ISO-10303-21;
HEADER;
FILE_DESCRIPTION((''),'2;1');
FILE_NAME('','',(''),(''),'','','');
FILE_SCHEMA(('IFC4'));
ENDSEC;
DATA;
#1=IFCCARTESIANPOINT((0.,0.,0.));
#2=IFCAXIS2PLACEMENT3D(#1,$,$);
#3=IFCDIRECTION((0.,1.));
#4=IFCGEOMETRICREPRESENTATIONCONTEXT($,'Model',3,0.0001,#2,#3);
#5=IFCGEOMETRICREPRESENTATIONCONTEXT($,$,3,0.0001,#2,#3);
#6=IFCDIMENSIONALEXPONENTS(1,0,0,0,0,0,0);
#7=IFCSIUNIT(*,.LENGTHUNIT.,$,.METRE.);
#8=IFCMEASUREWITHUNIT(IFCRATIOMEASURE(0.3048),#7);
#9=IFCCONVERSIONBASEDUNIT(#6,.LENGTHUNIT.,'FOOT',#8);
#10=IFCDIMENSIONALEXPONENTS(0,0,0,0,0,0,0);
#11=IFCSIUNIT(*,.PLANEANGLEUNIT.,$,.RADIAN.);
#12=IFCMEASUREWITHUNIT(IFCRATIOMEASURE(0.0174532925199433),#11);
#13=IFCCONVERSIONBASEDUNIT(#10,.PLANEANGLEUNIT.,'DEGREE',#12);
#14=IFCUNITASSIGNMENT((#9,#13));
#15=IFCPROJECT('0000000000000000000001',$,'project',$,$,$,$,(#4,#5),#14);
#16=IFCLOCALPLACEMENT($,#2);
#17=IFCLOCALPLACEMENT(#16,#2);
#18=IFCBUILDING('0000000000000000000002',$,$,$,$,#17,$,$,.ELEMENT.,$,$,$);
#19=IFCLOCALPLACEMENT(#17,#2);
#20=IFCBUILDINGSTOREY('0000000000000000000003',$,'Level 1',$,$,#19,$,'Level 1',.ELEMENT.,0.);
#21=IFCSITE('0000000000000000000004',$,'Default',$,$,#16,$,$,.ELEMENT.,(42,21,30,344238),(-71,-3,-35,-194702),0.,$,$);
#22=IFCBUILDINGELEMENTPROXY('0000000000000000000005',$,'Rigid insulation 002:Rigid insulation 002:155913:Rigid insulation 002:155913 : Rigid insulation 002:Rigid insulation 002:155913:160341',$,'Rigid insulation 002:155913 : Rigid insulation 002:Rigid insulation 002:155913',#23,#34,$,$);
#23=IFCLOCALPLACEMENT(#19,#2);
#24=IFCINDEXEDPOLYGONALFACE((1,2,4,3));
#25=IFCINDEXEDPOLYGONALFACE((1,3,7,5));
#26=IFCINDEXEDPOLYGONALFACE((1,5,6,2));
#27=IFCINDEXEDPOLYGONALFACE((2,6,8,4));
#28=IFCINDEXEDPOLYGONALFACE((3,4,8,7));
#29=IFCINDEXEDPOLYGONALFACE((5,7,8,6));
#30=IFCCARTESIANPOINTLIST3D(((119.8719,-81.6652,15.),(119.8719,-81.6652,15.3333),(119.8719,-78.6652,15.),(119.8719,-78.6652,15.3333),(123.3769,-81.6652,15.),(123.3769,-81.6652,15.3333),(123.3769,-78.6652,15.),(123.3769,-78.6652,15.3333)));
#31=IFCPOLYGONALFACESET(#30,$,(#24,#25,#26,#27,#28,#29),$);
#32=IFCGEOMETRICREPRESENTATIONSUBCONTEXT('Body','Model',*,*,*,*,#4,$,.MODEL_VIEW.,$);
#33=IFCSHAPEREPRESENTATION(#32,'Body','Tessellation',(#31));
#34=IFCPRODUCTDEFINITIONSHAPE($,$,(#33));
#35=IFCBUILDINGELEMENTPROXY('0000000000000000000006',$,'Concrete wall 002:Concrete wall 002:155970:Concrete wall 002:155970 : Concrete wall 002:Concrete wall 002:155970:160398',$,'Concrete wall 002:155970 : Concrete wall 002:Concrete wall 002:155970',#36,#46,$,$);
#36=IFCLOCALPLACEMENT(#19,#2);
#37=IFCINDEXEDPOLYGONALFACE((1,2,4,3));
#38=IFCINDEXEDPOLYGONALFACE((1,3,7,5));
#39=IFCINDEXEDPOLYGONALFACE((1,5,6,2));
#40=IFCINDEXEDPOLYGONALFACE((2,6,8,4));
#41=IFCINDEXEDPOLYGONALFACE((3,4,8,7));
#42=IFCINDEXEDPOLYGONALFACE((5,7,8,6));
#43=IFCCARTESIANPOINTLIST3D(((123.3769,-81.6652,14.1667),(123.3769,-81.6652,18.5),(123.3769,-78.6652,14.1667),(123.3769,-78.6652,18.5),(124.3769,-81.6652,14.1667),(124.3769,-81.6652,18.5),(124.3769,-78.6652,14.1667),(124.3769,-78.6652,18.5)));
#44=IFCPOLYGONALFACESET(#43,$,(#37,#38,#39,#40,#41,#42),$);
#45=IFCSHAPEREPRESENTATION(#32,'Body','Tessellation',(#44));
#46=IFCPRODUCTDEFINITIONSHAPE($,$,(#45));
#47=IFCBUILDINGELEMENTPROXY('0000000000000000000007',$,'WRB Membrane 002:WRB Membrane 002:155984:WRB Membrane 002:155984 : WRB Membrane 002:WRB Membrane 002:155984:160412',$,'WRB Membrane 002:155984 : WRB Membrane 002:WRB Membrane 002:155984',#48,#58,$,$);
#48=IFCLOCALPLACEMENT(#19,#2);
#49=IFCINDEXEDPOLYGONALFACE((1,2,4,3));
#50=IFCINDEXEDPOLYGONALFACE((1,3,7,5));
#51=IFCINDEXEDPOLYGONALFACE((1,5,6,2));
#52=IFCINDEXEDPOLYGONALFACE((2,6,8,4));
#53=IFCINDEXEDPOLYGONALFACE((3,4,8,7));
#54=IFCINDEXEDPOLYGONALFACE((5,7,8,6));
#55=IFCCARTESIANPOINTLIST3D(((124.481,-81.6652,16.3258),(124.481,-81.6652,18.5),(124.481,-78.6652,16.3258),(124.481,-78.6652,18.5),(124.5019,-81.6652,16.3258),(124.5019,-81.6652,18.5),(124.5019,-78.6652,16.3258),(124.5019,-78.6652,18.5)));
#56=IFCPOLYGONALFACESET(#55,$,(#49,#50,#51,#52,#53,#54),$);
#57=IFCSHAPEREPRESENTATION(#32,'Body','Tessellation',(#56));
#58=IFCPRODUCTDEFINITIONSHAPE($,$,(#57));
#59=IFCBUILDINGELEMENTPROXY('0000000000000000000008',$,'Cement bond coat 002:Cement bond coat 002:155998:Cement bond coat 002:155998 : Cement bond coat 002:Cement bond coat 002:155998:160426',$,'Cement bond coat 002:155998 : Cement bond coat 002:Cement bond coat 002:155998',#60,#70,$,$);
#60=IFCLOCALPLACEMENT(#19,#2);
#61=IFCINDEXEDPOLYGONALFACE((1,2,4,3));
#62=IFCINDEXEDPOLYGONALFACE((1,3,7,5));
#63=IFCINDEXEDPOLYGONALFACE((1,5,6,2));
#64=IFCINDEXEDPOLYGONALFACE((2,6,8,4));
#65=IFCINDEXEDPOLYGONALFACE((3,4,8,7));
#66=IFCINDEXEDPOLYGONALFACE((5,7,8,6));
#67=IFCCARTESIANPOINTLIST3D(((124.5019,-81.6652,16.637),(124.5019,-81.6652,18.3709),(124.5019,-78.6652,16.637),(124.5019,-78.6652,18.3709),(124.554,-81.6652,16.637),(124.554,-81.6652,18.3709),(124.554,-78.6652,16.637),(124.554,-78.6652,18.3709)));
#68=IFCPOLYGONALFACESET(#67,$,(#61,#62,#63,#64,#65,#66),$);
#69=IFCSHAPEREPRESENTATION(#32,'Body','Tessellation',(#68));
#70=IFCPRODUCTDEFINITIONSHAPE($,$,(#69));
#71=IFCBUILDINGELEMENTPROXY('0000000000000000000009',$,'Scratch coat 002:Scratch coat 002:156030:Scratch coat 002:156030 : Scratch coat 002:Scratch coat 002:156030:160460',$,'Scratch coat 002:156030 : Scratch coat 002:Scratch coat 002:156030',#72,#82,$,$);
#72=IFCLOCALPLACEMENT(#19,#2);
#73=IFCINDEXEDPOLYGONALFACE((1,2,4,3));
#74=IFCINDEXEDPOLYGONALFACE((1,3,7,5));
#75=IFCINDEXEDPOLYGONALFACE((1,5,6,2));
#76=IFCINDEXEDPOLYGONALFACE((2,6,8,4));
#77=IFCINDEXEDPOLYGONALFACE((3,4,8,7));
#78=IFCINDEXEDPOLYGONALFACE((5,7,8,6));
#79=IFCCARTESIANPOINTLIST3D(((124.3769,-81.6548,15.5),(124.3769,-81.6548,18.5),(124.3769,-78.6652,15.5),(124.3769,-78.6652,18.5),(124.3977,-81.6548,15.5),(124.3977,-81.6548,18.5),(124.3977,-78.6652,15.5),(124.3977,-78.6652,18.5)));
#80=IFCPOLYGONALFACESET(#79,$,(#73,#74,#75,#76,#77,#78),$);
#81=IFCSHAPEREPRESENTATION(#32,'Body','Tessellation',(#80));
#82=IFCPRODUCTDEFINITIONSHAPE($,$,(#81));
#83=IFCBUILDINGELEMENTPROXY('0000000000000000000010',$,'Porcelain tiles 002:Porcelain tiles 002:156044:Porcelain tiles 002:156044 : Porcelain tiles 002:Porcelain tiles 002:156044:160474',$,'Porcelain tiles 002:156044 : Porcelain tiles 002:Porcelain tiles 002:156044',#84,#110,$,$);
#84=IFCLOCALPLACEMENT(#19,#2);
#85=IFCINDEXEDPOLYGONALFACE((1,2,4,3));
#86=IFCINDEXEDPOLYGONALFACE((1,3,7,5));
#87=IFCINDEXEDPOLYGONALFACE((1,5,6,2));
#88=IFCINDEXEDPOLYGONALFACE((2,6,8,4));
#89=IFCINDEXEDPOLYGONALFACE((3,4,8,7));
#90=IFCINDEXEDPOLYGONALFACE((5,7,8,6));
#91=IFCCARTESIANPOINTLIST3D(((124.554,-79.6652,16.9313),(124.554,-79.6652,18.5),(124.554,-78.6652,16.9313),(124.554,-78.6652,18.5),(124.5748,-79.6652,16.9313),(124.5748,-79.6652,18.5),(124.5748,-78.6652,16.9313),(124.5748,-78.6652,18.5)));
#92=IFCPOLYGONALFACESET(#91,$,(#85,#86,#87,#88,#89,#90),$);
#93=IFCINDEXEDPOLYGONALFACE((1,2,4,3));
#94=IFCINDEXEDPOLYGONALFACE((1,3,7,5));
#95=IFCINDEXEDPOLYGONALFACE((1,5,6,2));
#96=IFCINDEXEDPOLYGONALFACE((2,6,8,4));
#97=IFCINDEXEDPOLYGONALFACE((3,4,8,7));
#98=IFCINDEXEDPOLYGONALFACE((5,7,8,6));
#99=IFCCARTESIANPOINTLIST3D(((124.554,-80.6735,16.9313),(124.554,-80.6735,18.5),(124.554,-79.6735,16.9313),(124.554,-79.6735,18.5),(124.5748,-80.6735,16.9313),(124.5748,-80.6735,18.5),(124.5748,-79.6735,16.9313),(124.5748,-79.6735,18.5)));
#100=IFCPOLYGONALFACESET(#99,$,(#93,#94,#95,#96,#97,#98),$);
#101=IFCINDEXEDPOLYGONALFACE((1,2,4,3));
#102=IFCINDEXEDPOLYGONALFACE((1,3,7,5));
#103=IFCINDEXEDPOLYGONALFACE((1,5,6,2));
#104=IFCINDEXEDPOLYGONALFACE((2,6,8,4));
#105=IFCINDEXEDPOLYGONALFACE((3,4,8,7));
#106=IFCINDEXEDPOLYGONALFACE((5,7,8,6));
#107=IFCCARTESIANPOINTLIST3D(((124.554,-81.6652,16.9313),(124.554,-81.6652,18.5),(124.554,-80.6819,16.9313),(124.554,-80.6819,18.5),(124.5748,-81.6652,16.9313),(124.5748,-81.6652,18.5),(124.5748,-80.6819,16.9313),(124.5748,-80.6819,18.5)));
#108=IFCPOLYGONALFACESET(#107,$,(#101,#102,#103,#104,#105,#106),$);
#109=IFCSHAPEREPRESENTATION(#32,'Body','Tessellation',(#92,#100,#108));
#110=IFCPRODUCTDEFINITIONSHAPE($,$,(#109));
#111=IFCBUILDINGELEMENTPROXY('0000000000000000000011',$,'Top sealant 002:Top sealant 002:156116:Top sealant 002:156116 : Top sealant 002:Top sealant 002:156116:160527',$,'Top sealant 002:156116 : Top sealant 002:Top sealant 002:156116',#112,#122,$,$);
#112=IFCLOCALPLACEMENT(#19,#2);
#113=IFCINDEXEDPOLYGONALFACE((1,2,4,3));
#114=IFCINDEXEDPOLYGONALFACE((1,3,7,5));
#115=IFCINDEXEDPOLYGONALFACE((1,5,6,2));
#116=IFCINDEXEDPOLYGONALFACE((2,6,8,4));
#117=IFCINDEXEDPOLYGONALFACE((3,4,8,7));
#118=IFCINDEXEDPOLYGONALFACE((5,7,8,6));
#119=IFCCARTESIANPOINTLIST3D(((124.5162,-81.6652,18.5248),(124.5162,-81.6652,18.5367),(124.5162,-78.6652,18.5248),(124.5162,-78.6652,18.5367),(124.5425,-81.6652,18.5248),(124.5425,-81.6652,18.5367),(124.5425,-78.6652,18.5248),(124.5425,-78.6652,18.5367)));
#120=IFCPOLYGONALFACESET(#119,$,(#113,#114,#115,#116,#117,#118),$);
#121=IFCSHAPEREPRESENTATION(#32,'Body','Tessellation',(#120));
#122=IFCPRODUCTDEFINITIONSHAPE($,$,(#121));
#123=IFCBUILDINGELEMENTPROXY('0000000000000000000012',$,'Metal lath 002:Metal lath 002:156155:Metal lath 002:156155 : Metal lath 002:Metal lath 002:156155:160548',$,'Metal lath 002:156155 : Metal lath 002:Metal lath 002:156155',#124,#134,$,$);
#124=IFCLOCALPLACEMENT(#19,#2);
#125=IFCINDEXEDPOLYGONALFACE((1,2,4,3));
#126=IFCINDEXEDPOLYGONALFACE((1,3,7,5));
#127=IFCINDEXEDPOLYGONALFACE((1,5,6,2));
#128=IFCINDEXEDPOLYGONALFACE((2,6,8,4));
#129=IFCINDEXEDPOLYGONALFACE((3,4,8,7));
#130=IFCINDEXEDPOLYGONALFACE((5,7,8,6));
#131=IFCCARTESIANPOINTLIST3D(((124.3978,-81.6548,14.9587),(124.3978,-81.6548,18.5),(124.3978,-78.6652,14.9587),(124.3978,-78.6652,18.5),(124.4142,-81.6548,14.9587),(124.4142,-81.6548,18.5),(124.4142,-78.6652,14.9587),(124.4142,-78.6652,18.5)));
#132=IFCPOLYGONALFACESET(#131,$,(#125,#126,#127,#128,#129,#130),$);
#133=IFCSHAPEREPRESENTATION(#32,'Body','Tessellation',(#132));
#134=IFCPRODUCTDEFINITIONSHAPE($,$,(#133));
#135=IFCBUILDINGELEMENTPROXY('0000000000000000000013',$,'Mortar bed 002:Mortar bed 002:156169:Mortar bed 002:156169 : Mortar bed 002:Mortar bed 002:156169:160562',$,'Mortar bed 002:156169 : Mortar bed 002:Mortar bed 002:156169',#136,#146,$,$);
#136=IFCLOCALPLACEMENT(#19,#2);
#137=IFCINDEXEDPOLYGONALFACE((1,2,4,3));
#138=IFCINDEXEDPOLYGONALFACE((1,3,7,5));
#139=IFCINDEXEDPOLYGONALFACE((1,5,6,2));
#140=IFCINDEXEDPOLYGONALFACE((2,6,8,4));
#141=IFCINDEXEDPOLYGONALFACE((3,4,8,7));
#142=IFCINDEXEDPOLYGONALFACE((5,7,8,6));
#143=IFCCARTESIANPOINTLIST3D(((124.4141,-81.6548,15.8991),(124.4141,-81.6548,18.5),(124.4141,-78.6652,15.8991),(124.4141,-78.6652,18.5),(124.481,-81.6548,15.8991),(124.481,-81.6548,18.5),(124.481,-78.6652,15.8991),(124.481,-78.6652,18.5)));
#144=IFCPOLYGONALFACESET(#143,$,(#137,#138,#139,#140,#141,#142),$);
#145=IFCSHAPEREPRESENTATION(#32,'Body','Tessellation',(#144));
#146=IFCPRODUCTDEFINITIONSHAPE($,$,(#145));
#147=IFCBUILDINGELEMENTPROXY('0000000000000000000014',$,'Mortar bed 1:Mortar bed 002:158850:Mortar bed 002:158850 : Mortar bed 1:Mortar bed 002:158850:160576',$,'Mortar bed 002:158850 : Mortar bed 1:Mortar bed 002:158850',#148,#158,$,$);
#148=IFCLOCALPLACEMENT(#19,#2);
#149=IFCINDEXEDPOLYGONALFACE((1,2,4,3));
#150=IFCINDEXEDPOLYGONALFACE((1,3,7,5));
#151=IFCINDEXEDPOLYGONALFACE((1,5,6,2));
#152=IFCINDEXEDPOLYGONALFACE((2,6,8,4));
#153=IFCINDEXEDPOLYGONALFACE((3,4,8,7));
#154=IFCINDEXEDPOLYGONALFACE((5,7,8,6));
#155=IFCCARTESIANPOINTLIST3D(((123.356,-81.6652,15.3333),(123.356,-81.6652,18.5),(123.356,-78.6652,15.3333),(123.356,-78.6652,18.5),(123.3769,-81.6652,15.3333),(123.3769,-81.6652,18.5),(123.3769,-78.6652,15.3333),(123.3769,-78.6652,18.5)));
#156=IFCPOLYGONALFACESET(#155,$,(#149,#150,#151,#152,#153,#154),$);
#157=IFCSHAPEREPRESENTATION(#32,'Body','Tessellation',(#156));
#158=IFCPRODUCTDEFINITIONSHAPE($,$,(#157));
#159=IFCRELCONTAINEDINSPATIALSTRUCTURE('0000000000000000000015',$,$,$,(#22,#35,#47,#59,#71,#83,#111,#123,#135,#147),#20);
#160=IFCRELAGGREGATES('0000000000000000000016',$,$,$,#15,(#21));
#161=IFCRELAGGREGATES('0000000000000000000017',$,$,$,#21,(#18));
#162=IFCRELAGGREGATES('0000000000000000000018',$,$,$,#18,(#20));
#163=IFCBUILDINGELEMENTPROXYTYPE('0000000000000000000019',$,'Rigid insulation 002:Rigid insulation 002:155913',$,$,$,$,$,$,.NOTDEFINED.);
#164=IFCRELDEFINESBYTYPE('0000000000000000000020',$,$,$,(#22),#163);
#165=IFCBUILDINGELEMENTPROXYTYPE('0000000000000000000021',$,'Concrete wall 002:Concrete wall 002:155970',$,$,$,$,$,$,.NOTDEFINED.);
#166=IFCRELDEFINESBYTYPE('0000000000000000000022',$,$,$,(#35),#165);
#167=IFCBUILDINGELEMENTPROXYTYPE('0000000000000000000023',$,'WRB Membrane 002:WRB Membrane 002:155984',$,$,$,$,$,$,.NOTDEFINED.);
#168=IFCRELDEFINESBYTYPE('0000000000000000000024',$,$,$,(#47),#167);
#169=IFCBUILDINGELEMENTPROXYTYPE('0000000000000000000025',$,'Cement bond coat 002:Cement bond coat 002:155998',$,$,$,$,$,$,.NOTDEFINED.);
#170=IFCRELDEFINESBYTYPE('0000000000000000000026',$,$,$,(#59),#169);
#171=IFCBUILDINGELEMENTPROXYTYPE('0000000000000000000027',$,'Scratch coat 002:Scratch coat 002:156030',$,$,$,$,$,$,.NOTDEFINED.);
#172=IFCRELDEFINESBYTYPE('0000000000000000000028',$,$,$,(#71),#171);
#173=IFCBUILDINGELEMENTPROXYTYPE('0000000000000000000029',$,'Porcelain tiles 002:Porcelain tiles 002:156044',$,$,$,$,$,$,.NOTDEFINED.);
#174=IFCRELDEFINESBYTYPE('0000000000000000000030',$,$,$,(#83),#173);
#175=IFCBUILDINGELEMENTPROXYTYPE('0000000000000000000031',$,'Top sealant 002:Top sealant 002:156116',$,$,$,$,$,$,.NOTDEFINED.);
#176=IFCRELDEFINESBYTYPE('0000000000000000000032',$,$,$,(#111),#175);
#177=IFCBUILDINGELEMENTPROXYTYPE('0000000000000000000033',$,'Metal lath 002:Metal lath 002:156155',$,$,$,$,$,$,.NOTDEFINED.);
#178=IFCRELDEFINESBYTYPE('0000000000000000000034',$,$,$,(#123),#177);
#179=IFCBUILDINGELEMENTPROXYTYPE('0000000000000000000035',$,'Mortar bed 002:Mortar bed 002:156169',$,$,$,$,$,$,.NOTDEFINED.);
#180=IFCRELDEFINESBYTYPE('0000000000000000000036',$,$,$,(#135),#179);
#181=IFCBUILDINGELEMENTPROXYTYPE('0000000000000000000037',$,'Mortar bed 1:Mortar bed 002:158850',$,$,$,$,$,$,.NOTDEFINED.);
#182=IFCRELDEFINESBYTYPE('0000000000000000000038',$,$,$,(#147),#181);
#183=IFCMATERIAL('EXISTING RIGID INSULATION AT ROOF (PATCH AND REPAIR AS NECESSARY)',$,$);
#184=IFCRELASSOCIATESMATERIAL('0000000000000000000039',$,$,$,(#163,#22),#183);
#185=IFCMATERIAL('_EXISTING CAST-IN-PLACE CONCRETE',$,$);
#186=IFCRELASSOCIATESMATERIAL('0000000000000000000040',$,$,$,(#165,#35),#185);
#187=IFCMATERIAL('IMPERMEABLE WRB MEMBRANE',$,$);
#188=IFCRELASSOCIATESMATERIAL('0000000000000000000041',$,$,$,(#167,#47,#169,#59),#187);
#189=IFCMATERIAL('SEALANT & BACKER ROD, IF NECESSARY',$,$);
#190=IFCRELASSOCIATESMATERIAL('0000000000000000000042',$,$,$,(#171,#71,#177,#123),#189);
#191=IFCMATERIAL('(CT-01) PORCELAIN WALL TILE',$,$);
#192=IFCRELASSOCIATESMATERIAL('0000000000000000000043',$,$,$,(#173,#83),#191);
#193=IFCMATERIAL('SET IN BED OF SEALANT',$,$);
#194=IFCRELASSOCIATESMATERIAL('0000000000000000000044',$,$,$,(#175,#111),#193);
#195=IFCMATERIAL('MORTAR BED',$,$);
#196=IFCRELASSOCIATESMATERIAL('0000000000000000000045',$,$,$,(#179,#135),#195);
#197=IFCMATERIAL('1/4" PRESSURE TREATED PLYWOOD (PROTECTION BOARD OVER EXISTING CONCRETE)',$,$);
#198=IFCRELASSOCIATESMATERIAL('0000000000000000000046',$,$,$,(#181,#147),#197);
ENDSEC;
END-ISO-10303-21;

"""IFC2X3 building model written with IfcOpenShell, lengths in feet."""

from ifc_helpers import new_model, entity, si_unit, converted_unit, direction, frame, frame_2d, origin, origin_2d_with_axis, place, context, subcontext, project, spatial, rectangle, extrude, source, transform, mapped, material, type_object, type_shapes, element, save


model = new_model("IFC2X3")

# Units and contexts
model_context = context("Model", 3, precision=0.0001, world=origin(), true_north=direction((0.0, 1.0)))
context_of_model = context(None, 3, precision=0.0001, world=origin(), true_north=direction((0.0, 1.0)))
body_context = subcontext(model_context, "Body", "Model", "MODEL_VIEW")
ifc_project = project(units=[converted_unit("LENGTHUNIT", "FOOT", entity("IfcRatioMeasure", 0.3048), si_unit("LENGTHUNIT", "METRE"), dimensions=[1, 0, 0, 0, 0, 0, 0]), converted_unit("PLANEANGLEUNIT", "DEGREE", entity("IfcRatioMeasure", 0.0174532925199433), si_unit("PLANEANGLEUNIT", "RADIAN"), dimensions=[0, 0, 0, 0, 0, 0, 0])], contexts=[model_context, context_of_model])

# Site, building, storey
site_placement = place(None, origin())
site = spatial("IfcSite", under=ifc_project, at=site_placement, Name="Default", CompositionType="ELEMENT", RefLatitude=(42, 21, 30, 344238), RefLongitude=(-71, -3, -35, -194702), RefElevation=0.0)
building_placement = place(site_placement, origin())
building = spatial("IfcBuilding", under=site, at=building_placement, CompositionType="ELEMENT")
storey_placement = place(building_placement, origin())
storey = spatial("IfcBuildingStorey", under=building, at=storey_placement, Name="Level 1", LongName="Level 1", CompositionType="ELEMENT", Elevation=0.0)

# Building element proxies
ifc_material_1 = material(Name="EXISTING RIGID INSULATION AT ROOF (PATCH AND REPAIR AS NECESSARY)")
building_element_proxy_type_1 = type_object("IfcBuildingElementProxyType", Name="Rigid insulation 002:Rigid insulation 002:155913", PredefinedType="NOTDEFINED", material=ifc_material_1)
shared_shape_1 = source(origin(), body_context, "Body", "SweptSolid", [
    extrude(rectangle(XDim=3.505, YDim=3.0, at=frame_2d((0.0, 0.0), x_axis=(1.0, 0.0))), frame((121.6244, -80.1652, 15.0), z_axis=(0.0, 0.0, 1.0), x_axis=(-1.0, 0.0, 0.0)), (0.0, 0.0, 1.0), 0.3333),
])
type_shapes(building_element_proxy_type_1, [shared_shape_1])
proxy_1_placement = place(storey_placement, origin())
element("IfcBuildingElementProxy", 1, at=proxy_1_placement, inside=storey, type_object=building_element_proxy_type_1, material=ifc_material_1, Name="Rigid insulation 002:Rigid insulation 002:155913:Rigid insulation 002:155913 : Rigid insulation 002:Rigid insulation 002:155913:160341", ObjectType="Rigid insulation 002:155913 : Rigid insulation 002:Rigid insulation 002:155913", context=body_context, shape_type="MappedRepresentation", body=[
    mapped(shared_shape_1, transform((0.0, 0.0, 0.0), scale=1.0)),
])
ifc_material_2 = material(Name="SEALANT & BACKER ROD, IF NECESSARY")
ifc_material_3 = material(Name="_EXISTING CAST-IN-PLACE CONCRETE")
building_element_proxy_type_2 = type_object("IfcBuildingElementProxyType", Name="Concrete wall 002:Concrete wall 002:155970", PredefinedType="NOTDEFINED", material=ifc_material_3)
shared_shape_2 = source(origin(), body_context, "Body", "SweptSolid", [
    extrude(rectangle(XDim=1.0, YDim=3.0, at=frame_2d((0.0, 0.0), x_axis=(1.0, 0.0))), frame((123.8769, -80.1652, 14.1667), z_axis=(0.0, 0.0, 1.0), x_axis=(-1.0, 0.0, 0.0)), (0.0, 0.0, 1.0), 4.3333),
])
type_shapes(building_element_proxy_type_2, [shared_shape_2])
proxy_2_placement = place(storey_placement, origin())
element("IfcBuildingElementProxy", 2, at=proxy_2_placement, inside=storey, type_object=building_element_proxy_type_2, material=ifc_material_3, Name="Concrete wall 002:Concrete wall 002:155970:Concrete wall 002:155970 : Concrete wall 002:Concrete wall 002:155970:160398", ObjectType="Concrete wall 002:155970 : Concrete wall 002:Concrete wall 002:155970", context=body_context, shape_type="MappedRepresentation", body=[
    mapped(shared_shape_2, transform((0.0, 0.0, 0.0), scale=1.0)),
])
ifc_material_4 = material(Name="IMPERMEABLE WRB MEMBRANE")
building_element_proxy_type_3 = type_object("IfcBuildingElementProxyType", Name="WRB Membrane 002:WRB Membrane 002:155984", PredefinedType="NOTDEFINED", material=ifc_material_4)
shared_shape_3 = source(origin(), body_context, "Body", "SweptSolid", [
    extrude(rectangle(XDim=0.0208, YDim=3.0, at=origin_2d_with_axis()), frame((124.4915, -80.1652, 16.3258), z_axis=(0.0, 0.0, 1.0), x_axis=(-1.0, 0.0, 0.0)), (0.0, 0.0, 1.0), 2.1742),
])
type_shapes(building_element_proxy_type_3, [shared_shape_3])
proxy_3_placement = place(storey_placement, origin())
element("IfcBuildingElementProxy", 3, at=proxy_3_placement, inside=storey, type_object=building_element_proxy_type_3, material=ifc_material_4, Name="WRB Membrane 002:WRB Membrane 002:155984:WRB Membrane 002:155984 : WRB Membrane 002:WRB Membrane 002:155984:160412", ObjectType="WRB Membrane 002:155984 : WRB Membrane 002:WRB Membrane 002:155984", context=body_context, shape_type="MappedRepresentation", body=[
    mapped(shared_shape_3, transform((0.0, 0.0, 0.0), scale=1.0)),
])
building_element_proxy_type_4 = type_object("IfcBuildingElementProxyType", Name="Cement bond coat 002:Cement bond coat 002:155998", PredefinedType="NOTDEFINED", material=ifc_material_4)
shared_shape_4 = source(origin(), body_context, "Body", "SweptSolid", [
    extrude(rectangle(XDim=0.0521, YDim=3.0, at=frame_2d((0.0, 0.0), x_axis=(1.0, 0.0))), frame((124.5279, -80.1652, 16.637), z_axis=(0.0, 0.0, 1.0), x_axis=(-1.0, 0.0, 0.0)), (0.0, 0.0, 1.0), 1.7339),
])
type_shapes(building_element_proxy_type_4, [shared_shape_4])
proxy_4_placement = place(storey_placement, origin())
element("IfcBuildingElementProxy", 4, at=proxy_4_placement, inside=storey, type_object=building_element_proxy_type_4, material=ifc_material_4, Name="Cement bond coat 002:Cement bond coat 002:155998:Cement bond coat 002:155998 : Cement bond coat 002:Cement bond coat 002:155998:160426", ObjectType="Cement bond coat 002:155998 : Cement bond coat 002:Cement bond coat 002:155998", context=body_context, shape_type="MappedRepresentation", body=[
    mapped(shared_shape_4, transform((0.0, 0.0, 0.0), scale=1.0)),
])
building_element_proxy_type_5 = type_object("IfcBuildingElementProxyType", Name="Scratch coat 002:Scratch coat 002:156030", PredefinedType="NOTDEFINED", material=ifc_material_2)
shared_shape_5 = source(origin(), body_context, "Body", "SweptSolid", [
    extrude(rectangle(XDim=0.0208, YDim=2.9896, at=frame_2d((0.0, 0.0), x_axis=(1.0, 0.0))), frame((124.3873, -80.16, 15.5), z_axis=(0.0, 0.0, 1.0), x_axis=(-1.0, 0.0, 0.0)), (0.0, 0.0, 1.0), 3.0),
])
type_shapes(building_element_proxy_type_5, [shared_shape_5])
proxy_5_placement = place(storey_placement, origin())
element("IfcBuildingElementProxy", 5, at=proxy_5_placement, inside=storey, type_object=building_element_proxy_type_5, material=ifc_material_2, Name="Scratch coat 002:Scratch coat 002:156030:Scratch coat 002:156030 : Scratch coat 002:Scratch coat 002:156030:160460", ObjectType="Scratch coat 002:156030 : Scratch coat 002:Scratch coat 002:156030", context=body_context, shape_type="MappedRepresentation", body=[
    mapped(shared_shape_5, transform((0.0, 0.0, 0.0), scale=1.0)),
])
ifc_material_5 = material(Name="(CT-01) PORCELAIN WALL TILE")
building_element_proxy_type_6 = type_object("IfcBuildingElementProxyType", Name="Porcelain tiles 002:Porcelain tiles 002:156044", PredefinedType="NOTDEFINED", material=ifc_material_5)
shared_shape_6 = source(origin(), body_context, "Body", "SweptSolid", [
    extrude(rectangle(XDim=0.0208, YDim=1.0, at=origin_2d_with_axis()), frame((124.5644, -79.1652, 16.9313)), (0.0, 0.0, 1.0), 1.5687),
    extrude(rectangle(XDim=0.0208, YDim=1.0, at=origin_2d_with_axis()), frame((124.5644, -80.1735, 16.9313)), (0.0, 0.0, 1.0), 1.5687),
    extrude(rectangle(XDim=0.9833, YDim=0.0208, at=frame_2d((0.0, 0.0), x_axis=(1.0, 0.0))), frame((124.5644, -81.1735, 16.9313), z_axis=(0.0, 0.0, 1.0), x_axis=(0.0, -1.0, 0.0)), (0.0, 0.0, 1.0), 1.5687),
])
type_shapes(building_element_proxy_type_6, [shared_shape_6])
proxy_6_placement = place(storey_placement, origin())
element("IfcBuildingElementProxy", 6, at=proxy_6_placement, inside=storey, type_object=building_element_proxy_type_6, material=ifc_material_5, Name="Porcelain tiles 002:Porcelain tiles 002:156044:Porcelain tiles 002:156044 : Porcelain tiles 002:Porcelain tiles 002:156044:160474", ObjectType="Porcelain tiles 002:156044 : Porcelain tiles 002:Porcelain tiles 002:156044", context=body_context, shape_type="MappedRepresentation", body=[
    mapped(shared_shape_6, transform((0.0, 0.0, 0.0), scale=1.0)),
])
ifc_material_6 = material(Name="SET IN BED OF SEALANT")
building_element_proxy_type_7 = type_object("IfcBuildingElementProxyType", Name="Top sealant 002:Top sealant 002:156116", PredefinedType="NOTDEFINED", material=ifc_material_6)
shared_shape_7 = source(origin(), body_context, "Body", "SweptSolid", [
    extrude(rectangle(XDim=0.0263, YDim=3.0, at=frame_2d((0.0, 0.0), x_axis=(1.0, 0.0))), frame((124.5293, -80.1652, 18.5248), z_axis=(0.0, 0.0, 1.0), x_axis=(-1.0, 0.0, 0.0)), (0.0, 0.0, 1.0), 0.0118),
])
type_shapes(building_element_proxy_type_7, [shared_shape_7])
proxy_7_placement = place(storey_placement, origin())
element("IfcBuildingElementProxy", 7, at=proxy_7_placement, inside=storey, type_object=building_element_proxy_type_7, material=ifc_material_6, Name="Top sealant 002:Top sealant 002:156116:Top sealant 002:156116 : Top sealant 002:Top sealant 002:156116:160527", ObjectType="Top sealant 002:156116 : Top sealant 002:Top sealant 002:156116", context=body_context, shape_type="MappedRepresentation", body=[
    mapped(shared_shape_7, transform((0.0, 0.0, 0.0), scale=1.0)),
])
building_element_proxy_type_8 = type_object("IfcBuildingElementProxyType", Name="Metal lath 002:Metal lath 002:156155", PredefinedType="NOTDEFINED", material=ifc_material_2)
shared_shape_8 = source(origin(), body_context, "Body", "SweptSolid", [
    extrude(rectangle(XDim=2.9896, YDim=0.0164, at=frame_2d((0.0, 0.0), x_axis=(1.0, 0.0))), frame((124.406, -80.16, 14.9587), z_axis=(0.0, 0.0, 1.0), x_axis=(0.0, 1.0, 0.0)), (0.0, 0.0, 1.0), 3.5413),
])
type_shapes(building_element_proxy_type_8, [shared_shape_8])
proxy_8_placement = place(storey_placement, origin())
element("IfcBuildingElementProxy", 8, at=proxy_8_placement, inside=storey, type_object=building_element_proxy_type_8, material=ifc_material_2, Name="Metal lath 002:Metal lath 002:156155:Metal lath 002:156155 : Metal lath 002:Metal lath 002:156155:160548", ObjectType="Metal lath 002:156155 : Metal lath 002:Metal lath 002:156155", context=body_context, shape_type="MappedRepresentation", body=[
    mapped(shared_shape_8, transform((0.0, 0.0, 0.0), scale=1.0)),
])
ifc_material_7 = material(Name="MORTAR BED")
building_element_proxy_type_9 = type_object("IfcBuildingElementProxyType", Name="Mortar bed 002:Mortar bed 002:156169", PredefinedType="NOTDEFINED", material=ifc_material_7)
shared_shape_9 = source(origin(), body_context, "Body", "SweptSolid", [
    extrude(rectangle(XDim=2.9896, YDim=0.0669, at=frame_2d((0.0, 0.0), x_axis=(1.0, 0.0))), frame((124.4476, -80.16, 15.8991), z_axis=(0.0, 0.0, 1.0), x_axis=(0.0, 1.0, 0.0)), (0.0, 0.0, 1.0), 2.6009),
])
type_shapes(building_element_proxy_type_9, [shared_shape_9])
proxy_9_placement = place(storey_placement, origin())
element("IfcBuildingElementProxy", 9, at=proxy_9_placement, inside=storey, type_object=building_element_proxy_type_9, material=ifc_material_7, Name="Mortar bed 002:Mortar bed 002:156169:Mortar bed 002:156169 : Mortar bed 002:Mortar bed 002:156169:160562", ObjectType="Mortar bed 002:156169 : Mortar bed 002:Mortar bed 002:156169", context=body_context, shape_type="MappedRepresentation", body=[
    mapped(shared_shape_9, transform((0.0, 0.0, 0.0), scale=1.0)),
])
ifc_material_8 = material(Name="1/4\" PRESSURE TREATED PLYWOOD (PROTECTION BOARD OVER EXISTING CONCRETE)")
building_element_proxy_type_10 = type_object("IfcBuildingElementProxyType", Name="Mortar bed 1:Mortar bed 002:158850", PredefinedType="NOTDEFINED", material=ifc_material_8)
shared_shape_10 = source(origin(), body_context, "Body", "SweptSolid", [
    extrude(rectangle(XDim=3.0, YDim=0.0208, at=origin_2d_with_axis()), frame((123.3665, -80.1652, 15.3333), z_axis=(0.0, 0.0, 1.0), x_axis=(0.0, 1.0, 0.0)), (0.0, 0.0, 1.0), 3.1667),
])
type_shapes(building_element_proxy_type_10, [shared_shape_10])
proxy_10_placement = place(storey_placement, origin())
element("IfcBuildingElementProxy", 10, at=proxy_10_placement, inside=storey, type_object=building_element_proxy_type_10, material=ifc_material_8, Name="Mortar bed 1:Mortar bed 002:158850:Mortar bed 002:158850 : Mortar bed 1:Mortar bed 002:158850:160576", ObjectType="Mortar bed 002:158850 : Mortar bed 1:Mortar bed 002:158850", context=body_context, shape_type="MappedRepresentation", body=[
    mapped(shared_shape_10, transform((0.0, 0.0, 0.0), scale=1.0)),
])

save(model, "model.ifc")
